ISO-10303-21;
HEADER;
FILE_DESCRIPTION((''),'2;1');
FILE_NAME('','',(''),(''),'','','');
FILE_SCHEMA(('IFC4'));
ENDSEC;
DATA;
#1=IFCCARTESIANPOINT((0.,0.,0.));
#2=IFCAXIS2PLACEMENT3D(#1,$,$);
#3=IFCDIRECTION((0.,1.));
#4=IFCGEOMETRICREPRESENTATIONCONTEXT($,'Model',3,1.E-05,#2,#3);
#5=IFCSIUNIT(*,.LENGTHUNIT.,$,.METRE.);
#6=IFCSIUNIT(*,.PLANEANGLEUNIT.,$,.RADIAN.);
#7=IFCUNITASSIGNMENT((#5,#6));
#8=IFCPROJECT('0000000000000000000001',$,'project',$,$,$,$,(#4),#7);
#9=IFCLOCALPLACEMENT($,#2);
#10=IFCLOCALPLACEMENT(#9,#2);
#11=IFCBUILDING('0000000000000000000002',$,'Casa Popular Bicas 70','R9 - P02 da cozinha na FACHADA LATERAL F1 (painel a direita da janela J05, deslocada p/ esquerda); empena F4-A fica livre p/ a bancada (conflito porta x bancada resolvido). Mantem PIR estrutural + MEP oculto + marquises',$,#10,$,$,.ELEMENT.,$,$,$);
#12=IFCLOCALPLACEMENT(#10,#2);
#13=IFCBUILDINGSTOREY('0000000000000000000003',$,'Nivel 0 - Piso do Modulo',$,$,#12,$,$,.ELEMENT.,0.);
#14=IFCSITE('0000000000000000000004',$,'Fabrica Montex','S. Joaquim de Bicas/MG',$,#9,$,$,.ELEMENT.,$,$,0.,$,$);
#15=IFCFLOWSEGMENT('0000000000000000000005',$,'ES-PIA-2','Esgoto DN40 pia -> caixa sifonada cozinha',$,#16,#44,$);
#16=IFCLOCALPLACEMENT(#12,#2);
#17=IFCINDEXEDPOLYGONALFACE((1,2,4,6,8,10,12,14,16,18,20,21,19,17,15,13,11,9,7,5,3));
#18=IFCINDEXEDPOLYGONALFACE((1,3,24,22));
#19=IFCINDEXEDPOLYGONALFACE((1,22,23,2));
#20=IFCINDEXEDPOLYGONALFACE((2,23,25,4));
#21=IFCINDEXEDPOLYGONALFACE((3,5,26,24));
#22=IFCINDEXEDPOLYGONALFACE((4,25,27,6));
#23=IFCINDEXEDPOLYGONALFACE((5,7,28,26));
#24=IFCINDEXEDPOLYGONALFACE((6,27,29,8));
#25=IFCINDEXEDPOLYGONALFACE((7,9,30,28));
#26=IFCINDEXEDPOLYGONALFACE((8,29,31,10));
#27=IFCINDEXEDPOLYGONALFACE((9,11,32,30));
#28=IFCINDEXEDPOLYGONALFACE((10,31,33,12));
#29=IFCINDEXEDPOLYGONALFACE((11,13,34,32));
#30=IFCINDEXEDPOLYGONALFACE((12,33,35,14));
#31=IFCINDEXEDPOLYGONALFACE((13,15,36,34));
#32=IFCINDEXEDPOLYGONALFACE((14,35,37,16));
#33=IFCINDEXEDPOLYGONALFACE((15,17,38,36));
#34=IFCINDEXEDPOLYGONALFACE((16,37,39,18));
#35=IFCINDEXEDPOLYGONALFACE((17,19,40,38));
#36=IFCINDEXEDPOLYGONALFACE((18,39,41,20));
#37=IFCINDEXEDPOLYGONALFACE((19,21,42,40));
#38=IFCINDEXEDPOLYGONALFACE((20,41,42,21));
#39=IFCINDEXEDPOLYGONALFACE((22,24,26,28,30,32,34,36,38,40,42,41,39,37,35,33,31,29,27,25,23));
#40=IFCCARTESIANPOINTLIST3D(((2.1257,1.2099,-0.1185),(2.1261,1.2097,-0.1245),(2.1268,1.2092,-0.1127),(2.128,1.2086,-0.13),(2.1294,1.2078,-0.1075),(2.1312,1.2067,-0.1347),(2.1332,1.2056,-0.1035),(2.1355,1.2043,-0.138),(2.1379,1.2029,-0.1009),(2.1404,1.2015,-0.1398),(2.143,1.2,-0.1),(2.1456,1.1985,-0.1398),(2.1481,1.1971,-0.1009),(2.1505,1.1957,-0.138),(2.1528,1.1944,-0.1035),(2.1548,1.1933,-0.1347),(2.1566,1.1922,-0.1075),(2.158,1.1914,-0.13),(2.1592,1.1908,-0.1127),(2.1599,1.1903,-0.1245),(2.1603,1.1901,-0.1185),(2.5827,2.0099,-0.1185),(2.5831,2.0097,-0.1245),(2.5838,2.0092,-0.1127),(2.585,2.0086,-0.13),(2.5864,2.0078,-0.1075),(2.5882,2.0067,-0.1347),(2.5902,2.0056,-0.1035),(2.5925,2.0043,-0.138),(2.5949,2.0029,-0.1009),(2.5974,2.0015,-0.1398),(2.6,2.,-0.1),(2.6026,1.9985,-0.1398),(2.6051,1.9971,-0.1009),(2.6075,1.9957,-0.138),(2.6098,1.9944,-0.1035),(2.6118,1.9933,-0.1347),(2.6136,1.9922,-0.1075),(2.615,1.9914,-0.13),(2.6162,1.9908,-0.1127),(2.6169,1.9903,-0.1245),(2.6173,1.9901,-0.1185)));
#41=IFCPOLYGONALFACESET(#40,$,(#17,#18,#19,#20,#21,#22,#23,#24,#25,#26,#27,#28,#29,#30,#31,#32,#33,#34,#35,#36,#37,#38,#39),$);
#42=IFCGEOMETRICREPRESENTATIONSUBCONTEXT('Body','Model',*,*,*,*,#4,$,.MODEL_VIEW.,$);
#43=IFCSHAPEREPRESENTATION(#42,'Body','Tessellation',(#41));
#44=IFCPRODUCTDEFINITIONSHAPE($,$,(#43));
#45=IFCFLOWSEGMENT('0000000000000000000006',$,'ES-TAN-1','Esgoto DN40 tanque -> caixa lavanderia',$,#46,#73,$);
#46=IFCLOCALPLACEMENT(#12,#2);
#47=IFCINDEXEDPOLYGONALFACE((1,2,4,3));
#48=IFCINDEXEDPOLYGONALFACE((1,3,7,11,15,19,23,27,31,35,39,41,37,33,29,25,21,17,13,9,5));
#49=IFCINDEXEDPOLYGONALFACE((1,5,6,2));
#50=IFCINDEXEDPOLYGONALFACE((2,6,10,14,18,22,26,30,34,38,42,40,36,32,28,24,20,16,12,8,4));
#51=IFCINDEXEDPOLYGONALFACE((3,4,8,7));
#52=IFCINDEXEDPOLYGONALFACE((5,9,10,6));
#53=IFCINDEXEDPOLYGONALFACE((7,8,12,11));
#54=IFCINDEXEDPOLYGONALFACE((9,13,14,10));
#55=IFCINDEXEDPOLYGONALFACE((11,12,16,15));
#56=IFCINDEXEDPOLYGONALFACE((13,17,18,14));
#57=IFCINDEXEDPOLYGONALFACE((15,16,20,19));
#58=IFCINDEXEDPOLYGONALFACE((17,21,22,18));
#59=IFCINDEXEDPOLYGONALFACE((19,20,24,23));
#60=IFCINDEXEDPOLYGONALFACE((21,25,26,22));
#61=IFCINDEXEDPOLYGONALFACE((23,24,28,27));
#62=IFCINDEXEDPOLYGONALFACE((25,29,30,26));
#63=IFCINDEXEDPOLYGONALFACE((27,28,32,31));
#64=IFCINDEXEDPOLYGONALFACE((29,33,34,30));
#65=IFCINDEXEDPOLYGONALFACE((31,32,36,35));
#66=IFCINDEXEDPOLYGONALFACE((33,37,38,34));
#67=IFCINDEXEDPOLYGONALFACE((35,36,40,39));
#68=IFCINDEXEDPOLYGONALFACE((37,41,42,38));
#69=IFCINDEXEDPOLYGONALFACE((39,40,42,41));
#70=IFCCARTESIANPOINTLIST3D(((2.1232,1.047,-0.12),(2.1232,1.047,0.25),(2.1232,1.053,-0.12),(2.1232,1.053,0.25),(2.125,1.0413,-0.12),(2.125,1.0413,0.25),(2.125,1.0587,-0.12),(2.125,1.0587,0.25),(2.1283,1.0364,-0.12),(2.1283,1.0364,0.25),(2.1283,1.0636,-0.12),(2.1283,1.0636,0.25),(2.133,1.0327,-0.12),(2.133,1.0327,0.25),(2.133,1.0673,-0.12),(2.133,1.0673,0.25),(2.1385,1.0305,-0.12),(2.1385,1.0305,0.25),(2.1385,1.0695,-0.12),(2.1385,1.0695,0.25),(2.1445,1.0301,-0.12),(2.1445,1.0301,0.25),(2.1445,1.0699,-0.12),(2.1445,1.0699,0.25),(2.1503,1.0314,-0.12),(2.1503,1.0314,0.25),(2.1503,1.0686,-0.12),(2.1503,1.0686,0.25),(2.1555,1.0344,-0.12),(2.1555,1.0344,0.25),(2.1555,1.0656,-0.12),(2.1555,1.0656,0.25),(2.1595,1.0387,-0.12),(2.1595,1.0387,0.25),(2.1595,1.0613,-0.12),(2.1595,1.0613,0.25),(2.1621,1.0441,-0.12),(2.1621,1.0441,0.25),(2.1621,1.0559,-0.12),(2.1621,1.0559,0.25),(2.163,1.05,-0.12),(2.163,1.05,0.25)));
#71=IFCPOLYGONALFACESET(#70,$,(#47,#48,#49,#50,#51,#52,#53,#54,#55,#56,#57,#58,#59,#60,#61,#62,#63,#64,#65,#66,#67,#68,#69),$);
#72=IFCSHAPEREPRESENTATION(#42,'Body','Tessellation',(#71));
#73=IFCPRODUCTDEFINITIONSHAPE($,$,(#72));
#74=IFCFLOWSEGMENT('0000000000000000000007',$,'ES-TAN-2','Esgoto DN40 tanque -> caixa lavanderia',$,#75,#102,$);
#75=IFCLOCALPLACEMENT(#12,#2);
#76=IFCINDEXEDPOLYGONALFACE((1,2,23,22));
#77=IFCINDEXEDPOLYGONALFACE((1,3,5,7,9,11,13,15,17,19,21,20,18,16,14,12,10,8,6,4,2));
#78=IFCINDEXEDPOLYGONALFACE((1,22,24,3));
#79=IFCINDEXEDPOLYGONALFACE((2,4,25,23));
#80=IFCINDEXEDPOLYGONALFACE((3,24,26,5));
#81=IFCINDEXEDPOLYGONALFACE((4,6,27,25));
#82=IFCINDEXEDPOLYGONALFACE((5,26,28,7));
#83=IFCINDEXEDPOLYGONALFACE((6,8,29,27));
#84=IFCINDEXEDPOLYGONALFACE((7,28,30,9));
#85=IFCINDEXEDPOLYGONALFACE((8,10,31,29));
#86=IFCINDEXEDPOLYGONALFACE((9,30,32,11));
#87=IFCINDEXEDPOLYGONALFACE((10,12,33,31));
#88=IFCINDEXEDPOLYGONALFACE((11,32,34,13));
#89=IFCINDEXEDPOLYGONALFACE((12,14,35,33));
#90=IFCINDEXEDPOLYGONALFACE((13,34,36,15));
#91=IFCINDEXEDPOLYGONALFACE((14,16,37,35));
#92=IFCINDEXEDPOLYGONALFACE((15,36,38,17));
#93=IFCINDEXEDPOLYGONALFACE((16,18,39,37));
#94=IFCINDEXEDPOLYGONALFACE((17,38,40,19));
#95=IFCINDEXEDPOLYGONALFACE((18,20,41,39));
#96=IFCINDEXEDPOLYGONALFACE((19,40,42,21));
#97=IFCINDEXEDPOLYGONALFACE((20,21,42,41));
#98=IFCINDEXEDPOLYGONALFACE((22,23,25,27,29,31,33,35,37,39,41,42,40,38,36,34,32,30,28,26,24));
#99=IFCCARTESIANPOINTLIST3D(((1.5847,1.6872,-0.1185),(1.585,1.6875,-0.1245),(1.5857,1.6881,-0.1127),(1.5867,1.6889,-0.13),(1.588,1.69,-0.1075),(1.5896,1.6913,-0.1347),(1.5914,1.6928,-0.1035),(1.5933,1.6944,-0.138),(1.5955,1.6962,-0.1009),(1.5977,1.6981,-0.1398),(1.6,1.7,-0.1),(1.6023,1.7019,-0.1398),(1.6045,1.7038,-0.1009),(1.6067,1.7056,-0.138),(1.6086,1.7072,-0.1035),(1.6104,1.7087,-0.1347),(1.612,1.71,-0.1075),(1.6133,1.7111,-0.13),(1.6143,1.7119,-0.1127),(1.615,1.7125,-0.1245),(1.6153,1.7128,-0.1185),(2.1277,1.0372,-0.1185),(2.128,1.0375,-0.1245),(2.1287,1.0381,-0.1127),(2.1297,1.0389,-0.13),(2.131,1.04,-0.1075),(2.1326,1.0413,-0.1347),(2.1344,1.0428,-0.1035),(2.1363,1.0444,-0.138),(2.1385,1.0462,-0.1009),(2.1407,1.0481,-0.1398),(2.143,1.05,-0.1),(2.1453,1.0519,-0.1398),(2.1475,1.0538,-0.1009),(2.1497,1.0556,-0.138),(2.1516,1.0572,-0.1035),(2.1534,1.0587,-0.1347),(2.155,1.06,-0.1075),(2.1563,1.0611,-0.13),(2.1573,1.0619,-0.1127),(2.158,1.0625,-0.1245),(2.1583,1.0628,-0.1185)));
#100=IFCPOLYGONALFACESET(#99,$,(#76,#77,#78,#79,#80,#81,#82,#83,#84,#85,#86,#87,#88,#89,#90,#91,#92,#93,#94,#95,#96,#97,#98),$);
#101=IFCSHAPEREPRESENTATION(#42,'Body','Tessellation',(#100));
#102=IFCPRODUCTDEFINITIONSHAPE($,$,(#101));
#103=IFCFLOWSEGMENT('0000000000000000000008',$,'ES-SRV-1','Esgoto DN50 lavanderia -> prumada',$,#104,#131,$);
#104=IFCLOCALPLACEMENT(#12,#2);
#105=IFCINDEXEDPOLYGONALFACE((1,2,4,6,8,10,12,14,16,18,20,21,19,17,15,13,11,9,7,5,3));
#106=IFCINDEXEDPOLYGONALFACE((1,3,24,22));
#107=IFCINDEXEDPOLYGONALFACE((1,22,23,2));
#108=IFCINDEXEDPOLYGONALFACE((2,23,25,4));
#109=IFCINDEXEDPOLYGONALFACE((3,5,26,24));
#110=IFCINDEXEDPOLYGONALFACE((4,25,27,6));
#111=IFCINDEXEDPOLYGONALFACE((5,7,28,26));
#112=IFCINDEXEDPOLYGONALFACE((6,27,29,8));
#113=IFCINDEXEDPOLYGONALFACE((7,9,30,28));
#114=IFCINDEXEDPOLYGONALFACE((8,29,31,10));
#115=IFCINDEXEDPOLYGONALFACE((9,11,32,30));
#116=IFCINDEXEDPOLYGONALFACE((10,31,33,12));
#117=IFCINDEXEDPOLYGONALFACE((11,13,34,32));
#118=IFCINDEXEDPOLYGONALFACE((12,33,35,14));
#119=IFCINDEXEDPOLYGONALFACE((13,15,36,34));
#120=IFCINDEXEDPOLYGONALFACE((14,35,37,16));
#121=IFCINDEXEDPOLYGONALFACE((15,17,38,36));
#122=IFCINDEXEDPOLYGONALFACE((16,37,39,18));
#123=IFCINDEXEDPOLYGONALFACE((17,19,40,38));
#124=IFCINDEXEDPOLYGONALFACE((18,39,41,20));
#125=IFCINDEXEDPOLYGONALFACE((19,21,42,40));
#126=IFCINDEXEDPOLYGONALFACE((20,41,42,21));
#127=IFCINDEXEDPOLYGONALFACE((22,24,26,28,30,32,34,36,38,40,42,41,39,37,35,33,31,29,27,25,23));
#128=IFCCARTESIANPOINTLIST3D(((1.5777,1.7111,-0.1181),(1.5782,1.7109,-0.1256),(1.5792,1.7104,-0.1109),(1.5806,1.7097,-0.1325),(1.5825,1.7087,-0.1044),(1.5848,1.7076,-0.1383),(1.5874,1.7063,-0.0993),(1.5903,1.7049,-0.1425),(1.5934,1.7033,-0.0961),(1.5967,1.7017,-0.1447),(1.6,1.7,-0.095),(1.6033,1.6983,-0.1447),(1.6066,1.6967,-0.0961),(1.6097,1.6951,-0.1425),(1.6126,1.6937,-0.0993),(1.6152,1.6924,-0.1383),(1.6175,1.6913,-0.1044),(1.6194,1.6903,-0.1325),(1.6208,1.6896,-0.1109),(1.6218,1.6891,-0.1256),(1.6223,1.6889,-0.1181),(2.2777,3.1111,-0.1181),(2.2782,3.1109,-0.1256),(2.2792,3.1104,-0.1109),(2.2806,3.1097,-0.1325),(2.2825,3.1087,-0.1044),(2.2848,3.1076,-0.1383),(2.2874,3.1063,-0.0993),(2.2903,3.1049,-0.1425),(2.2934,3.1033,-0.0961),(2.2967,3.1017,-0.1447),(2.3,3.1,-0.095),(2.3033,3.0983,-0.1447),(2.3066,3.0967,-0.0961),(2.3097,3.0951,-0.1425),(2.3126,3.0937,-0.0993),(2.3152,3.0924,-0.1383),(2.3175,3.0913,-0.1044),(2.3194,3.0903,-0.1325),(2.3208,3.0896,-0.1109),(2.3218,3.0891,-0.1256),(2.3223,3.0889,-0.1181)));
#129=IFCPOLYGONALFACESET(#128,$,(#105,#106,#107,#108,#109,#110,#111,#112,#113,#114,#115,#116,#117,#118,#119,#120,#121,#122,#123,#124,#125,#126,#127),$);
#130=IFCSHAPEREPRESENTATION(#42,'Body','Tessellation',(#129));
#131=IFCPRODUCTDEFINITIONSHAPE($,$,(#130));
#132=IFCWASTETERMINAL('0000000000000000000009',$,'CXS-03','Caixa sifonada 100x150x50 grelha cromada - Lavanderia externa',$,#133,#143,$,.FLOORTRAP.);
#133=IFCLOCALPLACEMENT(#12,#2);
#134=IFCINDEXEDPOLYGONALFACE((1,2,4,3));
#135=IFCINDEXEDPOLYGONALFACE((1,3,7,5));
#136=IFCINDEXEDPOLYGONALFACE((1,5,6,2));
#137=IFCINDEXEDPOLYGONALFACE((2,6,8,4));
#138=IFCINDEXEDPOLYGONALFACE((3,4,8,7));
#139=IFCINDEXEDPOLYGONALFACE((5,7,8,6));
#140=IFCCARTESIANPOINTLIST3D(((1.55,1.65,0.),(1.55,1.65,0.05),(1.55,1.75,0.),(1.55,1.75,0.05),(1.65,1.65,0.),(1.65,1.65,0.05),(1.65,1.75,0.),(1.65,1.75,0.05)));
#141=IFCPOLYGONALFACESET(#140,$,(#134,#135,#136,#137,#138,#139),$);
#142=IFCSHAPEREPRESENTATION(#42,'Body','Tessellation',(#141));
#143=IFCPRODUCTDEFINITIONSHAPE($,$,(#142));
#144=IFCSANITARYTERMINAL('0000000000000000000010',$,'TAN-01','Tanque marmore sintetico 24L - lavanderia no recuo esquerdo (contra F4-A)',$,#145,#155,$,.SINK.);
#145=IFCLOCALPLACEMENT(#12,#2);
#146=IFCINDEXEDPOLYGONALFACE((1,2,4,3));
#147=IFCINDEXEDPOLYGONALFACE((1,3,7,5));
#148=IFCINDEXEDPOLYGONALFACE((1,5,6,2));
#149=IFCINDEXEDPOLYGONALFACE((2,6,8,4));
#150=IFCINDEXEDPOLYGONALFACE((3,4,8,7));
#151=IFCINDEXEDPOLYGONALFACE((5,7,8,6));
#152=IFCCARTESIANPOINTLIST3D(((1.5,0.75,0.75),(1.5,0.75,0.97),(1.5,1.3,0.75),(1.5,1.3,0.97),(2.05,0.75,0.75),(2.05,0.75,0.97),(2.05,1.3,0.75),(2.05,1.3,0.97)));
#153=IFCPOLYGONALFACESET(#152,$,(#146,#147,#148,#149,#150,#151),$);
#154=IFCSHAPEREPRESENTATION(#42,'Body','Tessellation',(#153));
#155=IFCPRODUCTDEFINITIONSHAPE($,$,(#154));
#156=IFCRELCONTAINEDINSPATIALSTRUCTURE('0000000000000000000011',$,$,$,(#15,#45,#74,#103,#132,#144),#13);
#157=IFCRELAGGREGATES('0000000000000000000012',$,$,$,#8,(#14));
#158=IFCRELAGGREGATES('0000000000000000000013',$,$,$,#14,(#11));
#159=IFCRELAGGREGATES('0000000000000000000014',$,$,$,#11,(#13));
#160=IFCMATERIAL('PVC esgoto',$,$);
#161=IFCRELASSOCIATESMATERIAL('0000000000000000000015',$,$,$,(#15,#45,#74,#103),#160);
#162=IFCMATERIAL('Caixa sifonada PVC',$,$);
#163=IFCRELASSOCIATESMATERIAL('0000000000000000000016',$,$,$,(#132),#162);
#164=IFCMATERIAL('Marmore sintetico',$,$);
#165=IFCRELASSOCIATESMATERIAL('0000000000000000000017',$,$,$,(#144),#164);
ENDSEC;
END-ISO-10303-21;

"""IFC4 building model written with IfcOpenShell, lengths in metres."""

from ifc_helpers import new_model, si_unit, direction, frame, frame_2d, origin, origin_2d, place, context, subcontext, project, spatial, rectangle, circle, extrude, material, element, save


model = new_model("IFC4")

# Units and contexts
model_context = context("Model", 3, precision=1e-05, world=origin(), true_north=direction((0.0, 1.0)))
body_context = subcontext(model_context, "Body", "Model", "MODEL_VIEW")
ifc_project = project(units=[si_unit("LENGTHUNIT", "METRE"), si_unit("PLANEANGLEUNIT", "RADIAN")], contexts=[model_context])

# Site, building, storey
site_placement = place(None, origin())
site = spatial("IfcSite", under=ifc_project, at=site_placement, Name="Fabrica Montex", Description="S. Joaquim de Bicas/MG", CompositionType="ELEMENT", RefElevation=0.0)
building_placement = place(site_placement, origin())
building = spatial("IfcBuilding", under=site, at=building_placement, Name="Casa Popular Bicas 70", Description="R9 - P02 da cozinha na FACHADA LATERAL F1 (painel a direita da janela J05, deslocada p/ esquerda); empena F4-A fica livre p/ a bancada (conflito porta x bancada resolvido). Mantem PIR estrutural + MEP oculto + marquises", CompositionType="ELEMENT")
storey_placement = place(building_placement, origin())
storey = spatial("IfcBuildingStorey", under=building, at=storey_placement, Name="Nivel 0 - Piso do Modulo", CompositionType="ELEMENT", Elevation=0.0)

# Flow segments
ifc_material_1 = material(Name="PVC esgoto")
flow_segment_1_placement = place(storey_placement, frame((2.143, 1.2, -0.12), z_axis=(0.496022, 0.86831, 0.0), x_axis=(0.0, 0.0, 1.0)))
element("IfcFlowSegment", 1, at=flow_segment_1_placement, inside=storey, material=ifc_material_1, Name="ES-PIA-2", Description="Esgoto DN40 pia -> caixa sifonada cozinha", context=body_context, shape_type="SweptSolid", body=[
    extrude(circle(Radius=0.02, at=origin_2d()), origin(), (0.0, 0.0, 1.0), 0.9213),
])
flow_segment_2_placement = place(storey_placement, frame((2.143, 1.05, 0.25), z_axis=(0.0, 0.0, -1.0), x_axis=(1.0, 0.0, 0.0)))
element("IfcFlowSegment", 2, at=flow_segment_2_placement, inside=storey, material=ifc_material_1, Name="ES-TAN-1", Description="Esgoto DN40 tanque -> caixa lavanderia", context=body_context, shape_type="SweptSolid", body=[
    extrude(circle(Radius=0.02, at=origin_2d()), origin(), (0.0, 0.0, 1.0), 0.37),
])
flow_segment_3_placement = place(storey_placement, frame((2.143, 1.05, -0.12), z_axis=(-0.641113, 0.767446, 0.0), x_axis=(0.0, 0.0, 1.0)))
element("IfcFlowSegment", 3, at=flow_segment_3_placement, inside=storey, material=ifc_material_1, Name="ES-TAN-2", Description="Esgoto DN40 tanque -> caixa lavanderia", context=body_context, shape_type="SweptSolid", body=[
    extrude(circle(Radius=0.02, at=origin_2d()), origin(), (0.0, 0.0, 1.0), 0.847),
])
flow_segment_4_placement = place(storey_placement, frame((1.6, 1.7, -0.12), z_axis=(0.447214, 0.894427, 0.0), x_axis=(0.0, 0.0, 1.0)))
element("IfcFlowSegment", 4, at=flow_segment_4_placement, inside=storey, material=ifc_material_1, Name="ES-SRV-1", Description="Esgoto DN50 lavanderia -> prumada", context=body_context, shape_type="SweptSolid", body=[
    extrude(circle(Radius=0.025, at=origin_2d()), origin(), (0.0, 0.0, 1.0), 1.5652),
])

# Waste terminal
ifc_material_2 = material(Name="Caixa sifonada PVC")
waste_terminal_placement = place(storey_placement, frame((1.55, 1.65, 0.0)))
element("IfcWasteTerminal", 5, at=waste_terminal_placement, inside=storey, material=ifc_material_2, Name="CXS-03", Description="Caixa sifonada 100x150x50 grelha cromada - Lavanderia externa", PredefinedType="FLOORTRAP", context=body_context, shape_type="SweptSolid", body=[
    extrude(rectangle(XDim=0.1, YDim=0.1, at=frame_2d((0.05, 0.05))), origin(), (0.0, 0.0, 1.0), 0.05),
])

# Sanitary terminal
ifc_material_3 = material(Name="Marmore sintetico")
sanitary_terminal_placement = place(storey_placement, frame((1.5, 0.75, 0.75)))
element("IfcSanitaryTerminal", 6, at=sanitary_terminal_placement, inside=storey, material=ifc_material_3, Name="TAN-01", Description="Tanque marmore sintetico 24L - lavanderia no recuo esquerdo (contra F4-A)", PredefinedType="SINK", context=body_context, shape_type="SweptSolid", body=[
    extrude(rectangle(XDim=0.55, YDim=0.55, at=frame_2d((0.275, 0.275))), origin(), (0.0, 0.0, 1.0), 0.22),
])

save(model, "model.ifc")
